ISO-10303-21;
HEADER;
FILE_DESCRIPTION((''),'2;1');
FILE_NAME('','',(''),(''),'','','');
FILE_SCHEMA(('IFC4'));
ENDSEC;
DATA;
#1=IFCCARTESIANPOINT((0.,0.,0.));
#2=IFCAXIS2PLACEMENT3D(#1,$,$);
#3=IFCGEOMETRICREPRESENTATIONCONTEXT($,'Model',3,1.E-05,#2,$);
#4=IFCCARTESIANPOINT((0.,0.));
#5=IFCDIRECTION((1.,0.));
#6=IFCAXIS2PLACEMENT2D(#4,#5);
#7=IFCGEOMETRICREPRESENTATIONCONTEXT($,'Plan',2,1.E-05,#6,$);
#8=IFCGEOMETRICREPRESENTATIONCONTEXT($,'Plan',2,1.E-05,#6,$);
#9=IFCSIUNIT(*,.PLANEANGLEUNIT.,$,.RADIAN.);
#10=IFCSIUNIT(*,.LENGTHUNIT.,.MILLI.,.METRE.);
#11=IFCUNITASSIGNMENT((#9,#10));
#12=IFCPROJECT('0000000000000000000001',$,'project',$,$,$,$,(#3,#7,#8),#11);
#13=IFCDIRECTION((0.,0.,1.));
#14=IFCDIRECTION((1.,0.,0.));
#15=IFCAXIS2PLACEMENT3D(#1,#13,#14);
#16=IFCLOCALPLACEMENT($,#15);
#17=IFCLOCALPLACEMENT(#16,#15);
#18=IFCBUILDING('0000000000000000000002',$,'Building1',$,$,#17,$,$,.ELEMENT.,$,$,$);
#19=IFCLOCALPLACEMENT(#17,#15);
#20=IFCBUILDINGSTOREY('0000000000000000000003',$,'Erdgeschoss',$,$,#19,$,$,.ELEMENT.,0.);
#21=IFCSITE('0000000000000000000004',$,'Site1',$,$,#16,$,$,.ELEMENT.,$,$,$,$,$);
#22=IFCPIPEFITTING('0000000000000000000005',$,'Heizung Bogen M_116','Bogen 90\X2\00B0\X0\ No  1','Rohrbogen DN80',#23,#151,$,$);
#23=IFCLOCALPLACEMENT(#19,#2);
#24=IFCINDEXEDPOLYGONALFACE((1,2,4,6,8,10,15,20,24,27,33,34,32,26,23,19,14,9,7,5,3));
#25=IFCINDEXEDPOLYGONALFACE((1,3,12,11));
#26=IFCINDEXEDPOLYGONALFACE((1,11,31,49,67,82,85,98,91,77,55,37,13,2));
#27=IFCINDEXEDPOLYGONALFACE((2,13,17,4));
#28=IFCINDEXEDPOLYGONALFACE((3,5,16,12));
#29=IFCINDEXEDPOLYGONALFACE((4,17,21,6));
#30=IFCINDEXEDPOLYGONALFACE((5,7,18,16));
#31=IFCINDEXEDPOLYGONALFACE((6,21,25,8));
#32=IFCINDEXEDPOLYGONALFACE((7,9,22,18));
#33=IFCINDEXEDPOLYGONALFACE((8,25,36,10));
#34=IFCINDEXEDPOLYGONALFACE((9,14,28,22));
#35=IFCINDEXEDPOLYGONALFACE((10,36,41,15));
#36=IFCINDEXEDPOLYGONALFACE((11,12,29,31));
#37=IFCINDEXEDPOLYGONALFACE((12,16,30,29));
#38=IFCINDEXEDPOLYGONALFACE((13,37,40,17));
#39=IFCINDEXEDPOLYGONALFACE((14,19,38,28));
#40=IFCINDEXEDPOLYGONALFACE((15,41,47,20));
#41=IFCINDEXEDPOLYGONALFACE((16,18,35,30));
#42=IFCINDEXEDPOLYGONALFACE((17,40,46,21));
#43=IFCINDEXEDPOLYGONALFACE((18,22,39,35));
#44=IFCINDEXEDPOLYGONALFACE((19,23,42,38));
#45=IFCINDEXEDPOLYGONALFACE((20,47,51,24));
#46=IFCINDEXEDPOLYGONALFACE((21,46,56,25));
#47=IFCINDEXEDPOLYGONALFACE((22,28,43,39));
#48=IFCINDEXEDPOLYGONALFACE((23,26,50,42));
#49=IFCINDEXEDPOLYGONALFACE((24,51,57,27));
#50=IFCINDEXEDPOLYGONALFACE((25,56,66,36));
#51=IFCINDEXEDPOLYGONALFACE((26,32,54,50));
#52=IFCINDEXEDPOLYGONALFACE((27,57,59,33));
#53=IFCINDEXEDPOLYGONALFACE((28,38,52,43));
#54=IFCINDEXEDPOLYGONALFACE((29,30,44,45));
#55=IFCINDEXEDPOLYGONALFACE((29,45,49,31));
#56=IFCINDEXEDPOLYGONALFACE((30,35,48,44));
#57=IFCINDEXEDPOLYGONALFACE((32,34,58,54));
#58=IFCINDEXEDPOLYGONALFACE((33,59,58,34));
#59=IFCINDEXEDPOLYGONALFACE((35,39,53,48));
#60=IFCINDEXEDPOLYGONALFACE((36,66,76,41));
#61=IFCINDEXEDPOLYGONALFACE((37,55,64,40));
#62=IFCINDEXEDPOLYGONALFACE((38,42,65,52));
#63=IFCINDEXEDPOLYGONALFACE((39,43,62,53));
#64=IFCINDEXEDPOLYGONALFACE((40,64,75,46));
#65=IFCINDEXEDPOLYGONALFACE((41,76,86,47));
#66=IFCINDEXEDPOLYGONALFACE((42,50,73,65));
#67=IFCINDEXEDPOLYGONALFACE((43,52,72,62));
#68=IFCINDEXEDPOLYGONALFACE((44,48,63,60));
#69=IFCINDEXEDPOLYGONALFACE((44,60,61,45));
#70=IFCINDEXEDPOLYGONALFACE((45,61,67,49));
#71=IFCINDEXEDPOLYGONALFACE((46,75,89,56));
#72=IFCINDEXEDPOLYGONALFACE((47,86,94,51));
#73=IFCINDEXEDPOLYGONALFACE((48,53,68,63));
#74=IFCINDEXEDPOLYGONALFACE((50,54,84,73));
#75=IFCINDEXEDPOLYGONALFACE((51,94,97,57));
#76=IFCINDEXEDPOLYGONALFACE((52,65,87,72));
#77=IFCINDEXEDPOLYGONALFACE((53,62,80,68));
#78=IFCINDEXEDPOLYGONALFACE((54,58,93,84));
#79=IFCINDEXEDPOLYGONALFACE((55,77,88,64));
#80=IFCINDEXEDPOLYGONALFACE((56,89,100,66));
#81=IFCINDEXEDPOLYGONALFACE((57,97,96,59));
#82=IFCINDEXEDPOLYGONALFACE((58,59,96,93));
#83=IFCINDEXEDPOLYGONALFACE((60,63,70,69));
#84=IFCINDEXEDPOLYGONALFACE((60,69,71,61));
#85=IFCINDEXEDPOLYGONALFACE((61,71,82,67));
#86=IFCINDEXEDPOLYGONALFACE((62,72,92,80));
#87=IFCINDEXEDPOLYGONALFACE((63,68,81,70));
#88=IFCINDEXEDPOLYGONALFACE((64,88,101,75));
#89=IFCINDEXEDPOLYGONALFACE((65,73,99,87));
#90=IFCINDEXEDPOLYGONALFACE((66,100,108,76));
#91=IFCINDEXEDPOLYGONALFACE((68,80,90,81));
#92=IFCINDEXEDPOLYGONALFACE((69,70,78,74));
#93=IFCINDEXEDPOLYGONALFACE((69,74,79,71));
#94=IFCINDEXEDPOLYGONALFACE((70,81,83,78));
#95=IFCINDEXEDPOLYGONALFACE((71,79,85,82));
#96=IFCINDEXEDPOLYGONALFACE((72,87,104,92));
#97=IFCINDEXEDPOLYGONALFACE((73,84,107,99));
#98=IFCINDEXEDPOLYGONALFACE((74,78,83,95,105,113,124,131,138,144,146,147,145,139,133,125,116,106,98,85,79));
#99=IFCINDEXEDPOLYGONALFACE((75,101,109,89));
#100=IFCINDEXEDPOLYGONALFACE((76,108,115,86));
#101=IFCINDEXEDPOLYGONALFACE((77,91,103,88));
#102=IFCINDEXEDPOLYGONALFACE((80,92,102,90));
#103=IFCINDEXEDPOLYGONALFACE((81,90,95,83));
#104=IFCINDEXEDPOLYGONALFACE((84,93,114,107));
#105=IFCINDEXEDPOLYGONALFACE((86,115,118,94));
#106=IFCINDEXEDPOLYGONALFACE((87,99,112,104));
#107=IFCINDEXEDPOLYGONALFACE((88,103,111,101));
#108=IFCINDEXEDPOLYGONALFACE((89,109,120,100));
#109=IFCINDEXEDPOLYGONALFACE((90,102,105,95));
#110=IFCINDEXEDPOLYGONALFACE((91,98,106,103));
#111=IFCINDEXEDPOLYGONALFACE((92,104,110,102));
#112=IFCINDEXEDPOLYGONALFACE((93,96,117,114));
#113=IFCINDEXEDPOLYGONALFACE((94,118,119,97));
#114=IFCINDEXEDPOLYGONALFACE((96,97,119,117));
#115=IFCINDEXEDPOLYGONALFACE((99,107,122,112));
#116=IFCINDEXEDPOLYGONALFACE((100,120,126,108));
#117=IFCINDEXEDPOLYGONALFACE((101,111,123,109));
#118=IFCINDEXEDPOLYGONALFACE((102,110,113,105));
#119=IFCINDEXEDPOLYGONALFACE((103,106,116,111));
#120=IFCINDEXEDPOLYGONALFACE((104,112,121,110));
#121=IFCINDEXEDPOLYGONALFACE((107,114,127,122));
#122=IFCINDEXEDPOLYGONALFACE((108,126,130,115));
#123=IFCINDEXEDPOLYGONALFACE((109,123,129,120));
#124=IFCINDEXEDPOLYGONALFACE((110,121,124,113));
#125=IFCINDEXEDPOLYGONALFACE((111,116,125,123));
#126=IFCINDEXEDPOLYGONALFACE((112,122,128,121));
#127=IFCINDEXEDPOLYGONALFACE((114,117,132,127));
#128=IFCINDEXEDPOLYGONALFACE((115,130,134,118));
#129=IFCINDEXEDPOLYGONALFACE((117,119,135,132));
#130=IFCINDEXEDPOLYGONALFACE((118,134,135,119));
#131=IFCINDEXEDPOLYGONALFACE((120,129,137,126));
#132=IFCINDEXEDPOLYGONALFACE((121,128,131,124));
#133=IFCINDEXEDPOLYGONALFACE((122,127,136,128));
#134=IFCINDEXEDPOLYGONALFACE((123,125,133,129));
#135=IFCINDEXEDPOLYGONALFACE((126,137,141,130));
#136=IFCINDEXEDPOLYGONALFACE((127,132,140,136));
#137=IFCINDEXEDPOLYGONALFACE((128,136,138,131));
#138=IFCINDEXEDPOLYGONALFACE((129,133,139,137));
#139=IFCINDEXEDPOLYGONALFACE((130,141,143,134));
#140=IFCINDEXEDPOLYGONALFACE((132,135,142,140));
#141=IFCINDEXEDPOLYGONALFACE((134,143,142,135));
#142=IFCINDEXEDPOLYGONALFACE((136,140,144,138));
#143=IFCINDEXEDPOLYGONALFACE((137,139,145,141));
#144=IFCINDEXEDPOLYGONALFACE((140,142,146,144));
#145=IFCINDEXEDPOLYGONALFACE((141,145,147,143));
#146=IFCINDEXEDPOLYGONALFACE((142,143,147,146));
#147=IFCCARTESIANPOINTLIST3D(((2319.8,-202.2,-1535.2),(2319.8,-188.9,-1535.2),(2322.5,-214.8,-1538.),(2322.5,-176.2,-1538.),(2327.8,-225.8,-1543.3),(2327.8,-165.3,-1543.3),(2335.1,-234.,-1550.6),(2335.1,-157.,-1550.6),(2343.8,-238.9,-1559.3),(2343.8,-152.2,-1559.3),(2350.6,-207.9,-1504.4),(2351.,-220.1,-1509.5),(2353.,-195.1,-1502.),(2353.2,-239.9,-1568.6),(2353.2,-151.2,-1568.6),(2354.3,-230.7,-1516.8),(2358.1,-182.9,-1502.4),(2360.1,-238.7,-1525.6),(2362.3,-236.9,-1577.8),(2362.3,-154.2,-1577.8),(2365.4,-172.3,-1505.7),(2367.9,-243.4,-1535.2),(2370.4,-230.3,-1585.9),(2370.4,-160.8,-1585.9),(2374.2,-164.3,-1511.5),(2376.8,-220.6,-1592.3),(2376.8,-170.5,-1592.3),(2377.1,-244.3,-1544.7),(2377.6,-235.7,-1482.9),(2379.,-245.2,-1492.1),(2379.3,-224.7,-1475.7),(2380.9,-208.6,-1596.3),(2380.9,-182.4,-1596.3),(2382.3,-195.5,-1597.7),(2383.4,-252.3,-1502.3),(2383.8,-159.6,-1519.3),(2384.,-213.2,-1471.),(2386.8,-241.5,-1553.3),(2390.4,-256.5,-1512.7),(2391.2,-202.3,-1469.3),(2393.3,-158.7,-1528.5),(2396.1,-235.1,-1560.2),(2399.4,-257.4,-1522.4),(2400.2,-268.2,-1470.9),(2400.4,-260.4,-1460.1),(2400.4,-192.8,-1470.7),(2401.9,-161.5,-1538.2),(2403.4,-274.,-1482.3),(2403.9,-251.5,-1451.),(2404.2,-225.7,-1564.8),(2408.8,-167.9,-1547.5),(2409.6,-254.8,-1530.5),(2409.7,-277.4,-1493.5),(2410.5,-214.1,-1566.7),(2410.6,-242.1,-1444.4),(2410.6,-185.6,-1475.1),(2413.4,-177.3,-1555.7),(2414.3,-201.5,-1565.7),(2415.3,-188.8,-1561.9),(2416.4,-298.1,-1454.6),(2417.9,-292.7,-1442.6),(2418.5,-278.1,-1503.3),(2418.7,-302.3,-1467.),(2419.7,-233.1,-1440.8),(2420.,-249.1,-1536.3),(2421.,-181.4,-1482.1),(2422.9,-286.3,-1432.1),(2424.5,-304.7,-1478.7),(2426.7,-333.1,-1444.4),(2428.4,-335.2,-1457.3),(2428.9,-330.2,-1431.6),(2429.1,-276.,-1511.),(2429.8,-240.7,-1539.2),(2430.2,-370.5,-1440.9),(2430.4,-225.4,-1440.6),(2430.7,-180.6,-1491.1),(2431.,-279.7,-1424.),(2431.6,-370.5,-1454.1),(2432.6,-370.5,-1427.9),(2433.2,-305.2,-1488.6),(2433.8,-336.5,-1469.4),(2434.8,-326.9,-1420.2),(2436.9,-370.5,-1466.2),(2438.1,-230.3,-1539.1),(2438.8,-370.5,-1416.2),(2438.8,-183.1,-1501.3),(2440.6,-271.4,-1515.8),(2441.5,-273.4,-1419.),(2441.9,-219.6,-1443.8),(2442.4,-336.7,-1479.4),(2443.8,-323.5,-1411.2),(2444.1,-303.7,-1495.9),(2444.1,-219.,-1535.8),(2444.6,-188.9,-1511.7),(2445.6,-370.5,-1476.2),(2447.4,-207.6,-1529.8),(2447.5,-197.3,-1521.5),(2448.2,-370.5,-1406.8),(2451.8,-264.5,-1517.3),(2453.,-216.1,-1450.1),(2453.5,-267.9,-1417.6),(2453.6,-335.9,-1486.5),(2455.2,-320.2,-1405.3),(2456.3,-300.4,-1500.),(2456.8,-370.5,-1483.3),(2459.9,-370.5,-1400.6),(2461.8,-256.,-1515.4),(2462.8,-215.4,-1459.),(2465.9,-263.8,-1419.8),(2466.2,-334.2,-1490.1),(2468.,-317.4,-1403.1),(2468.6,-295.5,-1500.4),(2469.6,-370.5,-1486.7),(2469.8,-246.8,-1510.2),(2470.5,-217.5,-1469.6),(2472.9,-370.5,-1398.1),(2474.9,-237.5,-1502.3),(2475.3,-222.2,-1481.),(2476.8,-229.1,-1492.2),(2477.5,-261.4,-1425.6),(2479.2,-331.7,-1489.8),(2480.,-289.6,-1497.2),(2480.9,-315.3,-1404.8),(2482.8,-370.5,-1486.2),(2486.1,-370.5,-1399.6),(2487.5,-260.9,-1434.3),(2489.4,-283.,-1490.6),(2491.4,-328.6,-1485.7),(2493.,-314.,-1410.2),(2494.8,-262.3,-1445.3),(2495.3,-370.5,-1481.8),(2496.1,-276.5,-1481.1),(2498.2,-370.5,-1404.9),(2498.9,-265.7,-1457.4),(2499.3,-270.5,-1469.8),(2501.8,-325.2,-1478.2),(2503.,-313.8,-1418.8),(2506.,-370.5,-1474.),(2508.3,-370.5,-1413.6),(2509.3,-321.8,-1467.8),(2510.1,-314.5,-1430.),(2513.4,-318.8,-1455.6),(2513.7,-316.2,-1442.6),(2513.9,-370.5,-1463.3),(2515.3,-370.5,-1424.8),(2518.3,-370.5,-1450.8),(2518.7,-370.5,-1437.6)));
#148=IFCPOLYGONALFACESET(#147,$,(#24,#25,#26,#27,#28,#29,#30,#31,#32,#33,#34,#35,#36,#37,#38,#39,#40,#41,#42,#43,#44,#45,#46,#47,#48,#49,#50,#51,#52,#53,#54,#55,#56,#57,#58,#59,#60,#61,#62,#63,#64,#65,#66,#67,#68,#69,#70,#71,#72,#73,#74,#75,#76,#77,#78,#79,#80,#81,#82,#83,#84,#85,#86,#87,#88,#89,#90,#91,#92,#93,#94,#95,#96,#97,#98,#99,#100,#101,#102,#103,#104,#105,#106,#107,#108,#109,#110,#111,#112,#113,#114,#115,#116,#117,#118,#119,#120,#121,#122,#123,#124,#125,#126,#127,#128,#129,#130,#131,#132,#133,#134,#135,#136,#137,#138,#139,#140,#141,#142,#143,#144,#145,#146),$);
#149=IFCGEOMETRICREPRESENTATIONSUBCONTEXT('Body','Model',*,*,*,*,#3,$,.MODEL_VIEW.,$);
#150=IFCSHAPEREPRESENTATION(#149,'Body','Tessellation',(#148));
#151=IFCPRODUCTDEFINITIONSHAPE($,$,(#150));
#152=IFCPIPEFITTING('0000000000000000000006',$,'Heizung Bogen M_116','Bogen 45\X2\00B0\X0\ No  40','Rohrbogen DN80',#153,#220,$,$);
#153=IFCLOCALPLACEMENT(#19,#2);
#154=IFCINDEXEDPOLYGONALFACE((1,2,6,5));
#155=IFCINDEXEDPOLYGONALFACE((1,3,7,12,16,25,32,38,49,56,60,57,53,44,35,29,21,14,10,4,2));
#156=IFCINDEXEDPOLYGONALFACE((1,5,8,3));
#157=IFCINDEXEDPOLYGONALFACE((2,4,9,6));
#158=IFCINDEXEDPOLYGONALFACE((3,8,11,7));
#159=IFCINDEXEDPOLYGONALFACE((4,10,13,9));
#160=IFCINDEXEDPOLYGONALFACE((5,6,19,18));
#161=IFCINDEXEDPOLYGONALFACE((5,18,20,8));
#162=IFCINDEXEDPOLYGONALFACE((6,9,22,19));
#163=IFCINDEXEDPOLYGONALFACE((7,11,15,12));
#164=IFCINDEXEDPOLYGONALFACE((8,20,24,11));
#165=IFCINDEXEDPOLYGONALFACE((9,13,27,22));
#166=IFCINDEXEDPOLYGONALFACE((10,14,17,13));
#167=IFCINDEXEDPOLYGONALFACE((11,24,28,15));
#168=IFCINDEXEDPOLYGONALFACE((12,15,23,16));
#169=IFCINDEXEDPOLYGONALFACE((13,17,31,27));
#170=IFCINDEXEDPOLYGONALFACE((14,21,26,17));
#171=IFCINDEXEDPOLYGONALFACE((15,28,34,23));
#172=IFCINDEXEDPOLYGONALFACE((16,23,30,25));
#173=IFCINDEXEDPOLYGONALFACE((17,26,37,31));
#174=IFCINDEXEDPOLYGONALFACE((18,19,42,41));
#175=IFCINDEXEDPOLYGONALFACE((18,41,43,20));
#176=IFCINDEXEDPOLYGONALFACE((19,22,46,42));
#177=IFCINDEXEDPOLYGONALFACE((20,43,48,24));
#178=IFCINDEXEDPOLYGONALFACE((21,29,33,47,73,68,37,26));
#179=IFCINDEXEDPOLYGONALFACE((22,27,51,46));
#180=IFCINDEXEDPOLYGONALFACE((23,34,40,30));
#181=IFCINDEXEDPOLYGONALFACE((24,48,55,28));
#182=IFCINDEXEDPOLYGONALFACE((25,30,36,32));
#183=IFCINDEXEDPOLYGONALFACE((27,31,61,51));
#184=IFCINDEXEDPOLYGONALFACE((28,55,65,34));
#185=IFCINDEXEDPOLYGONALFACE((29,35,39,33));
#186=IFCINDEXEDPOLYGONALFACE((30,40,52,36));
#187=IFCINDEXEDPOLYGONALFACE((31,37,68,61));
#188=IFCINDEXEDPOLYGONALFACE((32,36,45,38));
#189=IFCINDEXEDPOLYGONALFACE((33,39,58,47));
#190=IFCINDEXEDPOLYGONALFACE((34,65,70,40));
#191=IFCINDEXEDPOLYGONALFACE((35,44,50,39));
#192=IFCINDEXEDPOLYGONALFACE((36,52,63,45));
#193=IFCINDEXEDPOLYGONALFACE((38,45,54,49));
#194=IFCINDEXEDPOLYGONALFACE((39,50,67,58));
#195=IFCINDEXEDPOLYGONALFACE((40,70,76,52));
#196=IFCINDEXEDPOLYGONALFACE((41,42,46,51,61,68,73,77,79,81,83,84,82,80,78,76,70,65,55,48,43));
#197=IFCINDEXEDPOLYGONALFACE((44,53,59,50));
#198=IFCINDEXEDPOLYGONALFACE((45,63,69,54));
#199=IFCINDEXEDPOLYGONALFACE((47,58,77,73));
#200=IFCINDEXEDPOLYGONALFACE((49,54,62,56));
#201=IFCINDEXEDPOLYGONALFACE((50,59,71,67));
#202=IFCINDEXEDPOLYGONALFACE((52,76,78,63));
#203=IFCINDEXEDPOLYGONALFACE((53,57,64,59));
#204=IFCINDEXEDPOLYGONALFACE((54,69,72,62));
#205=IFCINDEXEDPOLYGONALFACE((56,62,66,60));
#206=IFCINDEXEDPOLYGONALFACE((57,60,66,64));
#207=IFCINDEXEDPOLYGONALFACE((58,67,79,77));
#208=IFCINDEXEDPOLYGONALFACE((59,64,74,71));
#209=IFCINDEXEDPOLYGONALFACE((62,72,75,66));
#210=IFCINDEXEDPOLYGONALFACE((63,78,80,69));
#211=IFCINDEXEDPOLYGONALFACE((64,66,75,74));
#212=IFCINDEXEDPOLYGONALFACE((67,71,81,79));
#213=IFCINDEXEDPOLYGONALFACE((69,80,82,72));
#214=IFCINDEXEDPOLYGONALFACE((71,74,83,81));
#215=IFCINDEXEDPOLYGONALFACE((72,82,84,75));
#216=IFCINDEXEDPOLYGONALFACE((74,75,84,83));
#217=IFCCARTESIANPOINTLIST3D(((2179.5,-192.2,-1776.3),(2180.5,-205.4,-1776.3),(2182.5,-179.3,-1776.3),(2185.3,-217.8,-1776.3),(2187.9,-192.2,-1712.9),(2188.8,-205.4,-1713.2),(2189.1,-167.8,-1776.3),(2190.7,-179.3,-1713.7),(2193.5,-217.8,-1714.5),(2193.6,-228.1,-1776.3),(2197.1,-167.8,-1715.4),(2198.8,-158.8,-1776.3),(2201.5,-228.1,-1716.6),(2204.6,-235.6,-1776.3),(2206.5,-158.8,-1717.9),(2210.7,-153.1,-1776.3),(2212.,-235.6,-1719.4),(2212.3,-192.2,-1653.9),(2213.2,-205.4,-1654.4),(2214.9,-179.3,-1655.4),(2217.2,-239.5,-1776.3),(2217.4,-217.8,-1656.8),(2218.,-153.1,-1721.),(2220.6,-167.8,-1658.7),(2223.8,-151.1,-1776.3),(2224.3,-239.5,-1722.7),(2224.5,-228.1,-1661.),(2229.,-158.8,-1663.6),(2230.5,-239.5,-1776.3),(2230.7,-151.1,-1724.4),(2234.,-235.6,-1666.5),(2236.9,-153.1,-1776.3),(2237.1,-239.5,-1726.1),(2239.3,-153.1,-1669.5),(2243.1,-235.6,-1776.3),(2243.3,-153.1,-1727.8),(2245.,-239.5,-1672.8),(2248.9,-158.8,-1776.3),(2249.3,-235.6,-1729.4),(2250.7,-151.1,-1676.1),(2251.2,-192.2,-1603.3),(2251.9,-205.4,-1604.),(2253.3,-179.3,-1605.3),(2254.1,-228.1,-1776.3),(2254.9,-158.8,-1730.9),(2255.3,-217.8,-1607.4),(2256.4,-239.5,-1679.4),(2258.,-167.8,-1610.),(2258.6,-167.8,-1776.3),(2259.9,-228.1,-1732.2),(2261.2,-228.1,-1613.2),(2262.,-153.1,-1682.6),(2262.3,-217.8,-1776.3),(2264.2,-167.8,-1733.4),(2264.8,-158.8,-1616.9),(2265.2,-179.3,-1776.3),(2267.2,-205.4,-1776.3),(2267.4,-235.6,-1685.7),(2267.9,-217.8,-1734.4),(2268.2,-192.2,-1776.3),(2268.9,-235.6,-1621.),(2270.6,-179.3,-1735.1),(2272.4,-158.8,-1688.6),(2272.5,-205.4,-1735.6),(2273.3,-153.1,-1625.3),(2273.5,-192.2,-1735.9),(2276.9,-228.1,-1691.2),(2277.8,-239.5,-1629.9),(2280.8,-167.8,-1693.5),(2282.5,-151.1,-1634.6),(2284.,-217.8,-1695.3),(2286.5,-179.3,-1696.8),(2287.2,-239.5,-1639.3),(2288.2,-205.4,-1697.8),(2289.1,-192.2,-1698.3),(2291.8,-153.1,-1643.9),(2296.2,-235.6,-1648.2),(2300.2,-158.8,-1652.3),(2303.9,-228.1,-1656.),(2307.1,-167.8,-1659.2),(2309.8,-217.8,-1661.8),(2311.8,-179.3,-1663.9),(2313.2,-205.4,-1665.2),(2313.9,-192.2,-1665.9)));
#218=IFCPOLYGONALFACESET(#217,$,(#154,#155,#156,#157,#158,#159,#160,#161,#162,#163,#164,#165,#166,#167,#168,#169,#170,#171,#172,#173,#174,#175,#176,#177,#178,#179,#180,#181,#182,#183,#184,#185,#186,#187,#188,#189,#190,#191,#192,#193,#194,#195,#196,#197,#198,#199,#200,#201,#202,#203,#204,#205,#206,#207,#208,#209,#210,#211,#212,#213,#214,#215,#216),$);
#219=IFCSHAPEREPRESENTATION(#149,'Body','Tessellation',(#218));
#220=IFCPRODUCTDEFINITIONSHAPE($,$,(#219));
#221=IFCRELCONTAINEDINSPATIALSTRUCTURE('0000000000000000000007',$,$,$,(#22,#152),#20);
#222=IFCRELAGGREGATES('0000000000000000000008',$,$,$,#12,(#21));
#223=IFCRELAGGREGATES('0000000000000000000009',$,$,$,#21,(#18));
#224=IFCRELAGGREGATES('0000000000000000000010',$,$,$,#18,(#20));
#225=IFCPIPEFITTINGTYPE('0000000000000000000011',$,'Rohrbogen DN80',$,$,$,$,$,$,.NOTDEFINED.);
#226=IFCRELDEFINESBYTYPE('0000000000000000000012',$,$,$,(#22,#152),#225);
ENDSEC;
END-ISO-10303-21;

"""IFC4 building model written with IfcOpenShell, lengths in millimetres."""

from ifc_helpers import new_model, entity, si_unit, frame, origin, origin_with_axes, origin_2d_with_axis, place, context, subcontext, project, spatial, source, transform, mapped, type_object, element, save


model = new_model("IFC4")

# Units and contexts
model_context = context("Model", 3, precision=1e-05, world=origin())
plan_context_1 = context("Plan", 2, precision=1e-05, world=origin_2d_with_axis())
plan_context_2 = context("Plan", 2, precision=1e-05, world=origin_2d_with_axis())
body_context = subcontext(model_context, "Body", "Model", "MODEL_VIEW")
ifc_project = project(units=[si_unit("PLANEANGLEUNIT", "RADIAN"), si_unit("LENGTHUNIT", "METRE", prefix="MILLI")], contexts=[model_context, plan_context_1, plan_context_2])

# Site, building, storey
site_placement = place(None, origin_with_axes())
site = spatial("IfcSite", under=ifc_project, at=site_placement, Name="Site1", CompositionType="ELEMENT")
building_placement = place(site_placement, origin_with_axes())
building = spatial("IfcBuilding", under=site, at=building_placement, Name="Building1", CompositionType="ELEMENT")
storey_placement = place(building_placement, origin_with_axes())
storey = spatial("IfcBuildingStorey", under=building, at=storey_placement, Name="Erdgeschoss", CompositionType="ELEMENT", Elevation=0.0)

# Pipe fittings
pipe_fitting_type_1 = type_object("IfcPipeFittingType", Name="Rohrbogen DN80", PredefinedType="NOTDEFINED")
shared_shape_1 = source(origin_with_axes(), body_context, "Body", "SolidModel", [
    entity("IfcRevolvedAreaSolid", entity("IfcCircleProfileDef", "AREA", None, entity("IfcAxis2Placement2D", entity("IfcCartesianPoint", [0.0, 0.0]), entity("IfcDirection", [1.0, 0.0])), 44.5), entity("IfcAxis2Placement3D", entity("IfcCartesianPoint", [-109.7, 46.2, -46.2]), entity("IfcDirection", [1.0, 0.0, 0.0]), entity("IfcDirection", [0.0, 0.707107, 0.707107])), entity("IfcAxis1Placement", entity("IfcCartesianPoint", [0.0, 175.0, 0.0]), entity("IfcDirection", [-1.0, 0.0, 0.0])), 1.570796),
])
pipe_fitting_1_placement = place(storey_placement, frame((2428.4, -260.8, -1488.7), z_axis=(0.0, 0.0, 1.0), x_axis=(1.0, 0.0, 0.0)))
element("IfcPipeFitting", 1, at=pipe_fitting_1_placement, inside=storey, type_object=pipe_fitting_type_1, Name="Heizung Bogen M_116", Description="Bogen 90° No  1", ObjectType="Rohrbogen DN80", context=body_context, shape_type="MappedRepresentation", body=[
    mapped(shared_shape_1, transform((0.0, 0.0, 0.0), x_axis=(0.0, 1.0, 0.0), y_axis=(1.0, 0.0, 0.0), z_axis=(0.0, 0.0, -1.0), scale=1.0)),
])
shared_shape_2 = source(origin_with_axes(), body_context, "Body", "SolidModel", [
    entity("IfcRevolvedAreaSolid", entity("IfcCircleProfileDef", "AREA", None, entity("IfcAxis2Placement2D", entity("IfcCartesianPoint", [0.0, 0.0]), entity("IfcDirection", [1.0, 0.0])), 44.5), entity("IfcAxis2Placement3D", entity("IfcCartesianPoint", [79.5, 22.8, 0.0]), entity("IfcDirection", [-1.0, 0.0, 0.0]), entity("IfcDirection", [0.0, 0.0, -1.0])), entity("IfcAxis1Placement", entity("IfcCartesianPoint", [0.0, 200.4, 0.0]), entity("IfcDirection", [-1.0, 0.0, 0.0])), 0.785398),
])
pipe_fitting_2_placement = place(storey_placement, frame((2242.5, -195.5, -1706.9), z_axis=(0.0, 0.0, 1.0), x_axis=(1.0, 0.0, 0.0)))
element("IfcPipeFitting", 2, at=pipe_fitting_2_placement, inside=storey, type_object=pipe_fitting_type_1, Name="Heizung Bogen M_116", Description="Bogen 45° No  40", ObjectType="Rohrbogen DN80", context=body_context, shape_type="MappedRepresentation", body=[
    mapped(shared_shape_2, transform((0.0, 0.0, 0.0), x_axis=(0.707107, 0.0, 0.707107), y_axis=(-0.707107, 0.0, 0.707107), z_axis=(0.0, -1.0, 0.0), scale=1.0)),
])

save(model, "model.ifc")
